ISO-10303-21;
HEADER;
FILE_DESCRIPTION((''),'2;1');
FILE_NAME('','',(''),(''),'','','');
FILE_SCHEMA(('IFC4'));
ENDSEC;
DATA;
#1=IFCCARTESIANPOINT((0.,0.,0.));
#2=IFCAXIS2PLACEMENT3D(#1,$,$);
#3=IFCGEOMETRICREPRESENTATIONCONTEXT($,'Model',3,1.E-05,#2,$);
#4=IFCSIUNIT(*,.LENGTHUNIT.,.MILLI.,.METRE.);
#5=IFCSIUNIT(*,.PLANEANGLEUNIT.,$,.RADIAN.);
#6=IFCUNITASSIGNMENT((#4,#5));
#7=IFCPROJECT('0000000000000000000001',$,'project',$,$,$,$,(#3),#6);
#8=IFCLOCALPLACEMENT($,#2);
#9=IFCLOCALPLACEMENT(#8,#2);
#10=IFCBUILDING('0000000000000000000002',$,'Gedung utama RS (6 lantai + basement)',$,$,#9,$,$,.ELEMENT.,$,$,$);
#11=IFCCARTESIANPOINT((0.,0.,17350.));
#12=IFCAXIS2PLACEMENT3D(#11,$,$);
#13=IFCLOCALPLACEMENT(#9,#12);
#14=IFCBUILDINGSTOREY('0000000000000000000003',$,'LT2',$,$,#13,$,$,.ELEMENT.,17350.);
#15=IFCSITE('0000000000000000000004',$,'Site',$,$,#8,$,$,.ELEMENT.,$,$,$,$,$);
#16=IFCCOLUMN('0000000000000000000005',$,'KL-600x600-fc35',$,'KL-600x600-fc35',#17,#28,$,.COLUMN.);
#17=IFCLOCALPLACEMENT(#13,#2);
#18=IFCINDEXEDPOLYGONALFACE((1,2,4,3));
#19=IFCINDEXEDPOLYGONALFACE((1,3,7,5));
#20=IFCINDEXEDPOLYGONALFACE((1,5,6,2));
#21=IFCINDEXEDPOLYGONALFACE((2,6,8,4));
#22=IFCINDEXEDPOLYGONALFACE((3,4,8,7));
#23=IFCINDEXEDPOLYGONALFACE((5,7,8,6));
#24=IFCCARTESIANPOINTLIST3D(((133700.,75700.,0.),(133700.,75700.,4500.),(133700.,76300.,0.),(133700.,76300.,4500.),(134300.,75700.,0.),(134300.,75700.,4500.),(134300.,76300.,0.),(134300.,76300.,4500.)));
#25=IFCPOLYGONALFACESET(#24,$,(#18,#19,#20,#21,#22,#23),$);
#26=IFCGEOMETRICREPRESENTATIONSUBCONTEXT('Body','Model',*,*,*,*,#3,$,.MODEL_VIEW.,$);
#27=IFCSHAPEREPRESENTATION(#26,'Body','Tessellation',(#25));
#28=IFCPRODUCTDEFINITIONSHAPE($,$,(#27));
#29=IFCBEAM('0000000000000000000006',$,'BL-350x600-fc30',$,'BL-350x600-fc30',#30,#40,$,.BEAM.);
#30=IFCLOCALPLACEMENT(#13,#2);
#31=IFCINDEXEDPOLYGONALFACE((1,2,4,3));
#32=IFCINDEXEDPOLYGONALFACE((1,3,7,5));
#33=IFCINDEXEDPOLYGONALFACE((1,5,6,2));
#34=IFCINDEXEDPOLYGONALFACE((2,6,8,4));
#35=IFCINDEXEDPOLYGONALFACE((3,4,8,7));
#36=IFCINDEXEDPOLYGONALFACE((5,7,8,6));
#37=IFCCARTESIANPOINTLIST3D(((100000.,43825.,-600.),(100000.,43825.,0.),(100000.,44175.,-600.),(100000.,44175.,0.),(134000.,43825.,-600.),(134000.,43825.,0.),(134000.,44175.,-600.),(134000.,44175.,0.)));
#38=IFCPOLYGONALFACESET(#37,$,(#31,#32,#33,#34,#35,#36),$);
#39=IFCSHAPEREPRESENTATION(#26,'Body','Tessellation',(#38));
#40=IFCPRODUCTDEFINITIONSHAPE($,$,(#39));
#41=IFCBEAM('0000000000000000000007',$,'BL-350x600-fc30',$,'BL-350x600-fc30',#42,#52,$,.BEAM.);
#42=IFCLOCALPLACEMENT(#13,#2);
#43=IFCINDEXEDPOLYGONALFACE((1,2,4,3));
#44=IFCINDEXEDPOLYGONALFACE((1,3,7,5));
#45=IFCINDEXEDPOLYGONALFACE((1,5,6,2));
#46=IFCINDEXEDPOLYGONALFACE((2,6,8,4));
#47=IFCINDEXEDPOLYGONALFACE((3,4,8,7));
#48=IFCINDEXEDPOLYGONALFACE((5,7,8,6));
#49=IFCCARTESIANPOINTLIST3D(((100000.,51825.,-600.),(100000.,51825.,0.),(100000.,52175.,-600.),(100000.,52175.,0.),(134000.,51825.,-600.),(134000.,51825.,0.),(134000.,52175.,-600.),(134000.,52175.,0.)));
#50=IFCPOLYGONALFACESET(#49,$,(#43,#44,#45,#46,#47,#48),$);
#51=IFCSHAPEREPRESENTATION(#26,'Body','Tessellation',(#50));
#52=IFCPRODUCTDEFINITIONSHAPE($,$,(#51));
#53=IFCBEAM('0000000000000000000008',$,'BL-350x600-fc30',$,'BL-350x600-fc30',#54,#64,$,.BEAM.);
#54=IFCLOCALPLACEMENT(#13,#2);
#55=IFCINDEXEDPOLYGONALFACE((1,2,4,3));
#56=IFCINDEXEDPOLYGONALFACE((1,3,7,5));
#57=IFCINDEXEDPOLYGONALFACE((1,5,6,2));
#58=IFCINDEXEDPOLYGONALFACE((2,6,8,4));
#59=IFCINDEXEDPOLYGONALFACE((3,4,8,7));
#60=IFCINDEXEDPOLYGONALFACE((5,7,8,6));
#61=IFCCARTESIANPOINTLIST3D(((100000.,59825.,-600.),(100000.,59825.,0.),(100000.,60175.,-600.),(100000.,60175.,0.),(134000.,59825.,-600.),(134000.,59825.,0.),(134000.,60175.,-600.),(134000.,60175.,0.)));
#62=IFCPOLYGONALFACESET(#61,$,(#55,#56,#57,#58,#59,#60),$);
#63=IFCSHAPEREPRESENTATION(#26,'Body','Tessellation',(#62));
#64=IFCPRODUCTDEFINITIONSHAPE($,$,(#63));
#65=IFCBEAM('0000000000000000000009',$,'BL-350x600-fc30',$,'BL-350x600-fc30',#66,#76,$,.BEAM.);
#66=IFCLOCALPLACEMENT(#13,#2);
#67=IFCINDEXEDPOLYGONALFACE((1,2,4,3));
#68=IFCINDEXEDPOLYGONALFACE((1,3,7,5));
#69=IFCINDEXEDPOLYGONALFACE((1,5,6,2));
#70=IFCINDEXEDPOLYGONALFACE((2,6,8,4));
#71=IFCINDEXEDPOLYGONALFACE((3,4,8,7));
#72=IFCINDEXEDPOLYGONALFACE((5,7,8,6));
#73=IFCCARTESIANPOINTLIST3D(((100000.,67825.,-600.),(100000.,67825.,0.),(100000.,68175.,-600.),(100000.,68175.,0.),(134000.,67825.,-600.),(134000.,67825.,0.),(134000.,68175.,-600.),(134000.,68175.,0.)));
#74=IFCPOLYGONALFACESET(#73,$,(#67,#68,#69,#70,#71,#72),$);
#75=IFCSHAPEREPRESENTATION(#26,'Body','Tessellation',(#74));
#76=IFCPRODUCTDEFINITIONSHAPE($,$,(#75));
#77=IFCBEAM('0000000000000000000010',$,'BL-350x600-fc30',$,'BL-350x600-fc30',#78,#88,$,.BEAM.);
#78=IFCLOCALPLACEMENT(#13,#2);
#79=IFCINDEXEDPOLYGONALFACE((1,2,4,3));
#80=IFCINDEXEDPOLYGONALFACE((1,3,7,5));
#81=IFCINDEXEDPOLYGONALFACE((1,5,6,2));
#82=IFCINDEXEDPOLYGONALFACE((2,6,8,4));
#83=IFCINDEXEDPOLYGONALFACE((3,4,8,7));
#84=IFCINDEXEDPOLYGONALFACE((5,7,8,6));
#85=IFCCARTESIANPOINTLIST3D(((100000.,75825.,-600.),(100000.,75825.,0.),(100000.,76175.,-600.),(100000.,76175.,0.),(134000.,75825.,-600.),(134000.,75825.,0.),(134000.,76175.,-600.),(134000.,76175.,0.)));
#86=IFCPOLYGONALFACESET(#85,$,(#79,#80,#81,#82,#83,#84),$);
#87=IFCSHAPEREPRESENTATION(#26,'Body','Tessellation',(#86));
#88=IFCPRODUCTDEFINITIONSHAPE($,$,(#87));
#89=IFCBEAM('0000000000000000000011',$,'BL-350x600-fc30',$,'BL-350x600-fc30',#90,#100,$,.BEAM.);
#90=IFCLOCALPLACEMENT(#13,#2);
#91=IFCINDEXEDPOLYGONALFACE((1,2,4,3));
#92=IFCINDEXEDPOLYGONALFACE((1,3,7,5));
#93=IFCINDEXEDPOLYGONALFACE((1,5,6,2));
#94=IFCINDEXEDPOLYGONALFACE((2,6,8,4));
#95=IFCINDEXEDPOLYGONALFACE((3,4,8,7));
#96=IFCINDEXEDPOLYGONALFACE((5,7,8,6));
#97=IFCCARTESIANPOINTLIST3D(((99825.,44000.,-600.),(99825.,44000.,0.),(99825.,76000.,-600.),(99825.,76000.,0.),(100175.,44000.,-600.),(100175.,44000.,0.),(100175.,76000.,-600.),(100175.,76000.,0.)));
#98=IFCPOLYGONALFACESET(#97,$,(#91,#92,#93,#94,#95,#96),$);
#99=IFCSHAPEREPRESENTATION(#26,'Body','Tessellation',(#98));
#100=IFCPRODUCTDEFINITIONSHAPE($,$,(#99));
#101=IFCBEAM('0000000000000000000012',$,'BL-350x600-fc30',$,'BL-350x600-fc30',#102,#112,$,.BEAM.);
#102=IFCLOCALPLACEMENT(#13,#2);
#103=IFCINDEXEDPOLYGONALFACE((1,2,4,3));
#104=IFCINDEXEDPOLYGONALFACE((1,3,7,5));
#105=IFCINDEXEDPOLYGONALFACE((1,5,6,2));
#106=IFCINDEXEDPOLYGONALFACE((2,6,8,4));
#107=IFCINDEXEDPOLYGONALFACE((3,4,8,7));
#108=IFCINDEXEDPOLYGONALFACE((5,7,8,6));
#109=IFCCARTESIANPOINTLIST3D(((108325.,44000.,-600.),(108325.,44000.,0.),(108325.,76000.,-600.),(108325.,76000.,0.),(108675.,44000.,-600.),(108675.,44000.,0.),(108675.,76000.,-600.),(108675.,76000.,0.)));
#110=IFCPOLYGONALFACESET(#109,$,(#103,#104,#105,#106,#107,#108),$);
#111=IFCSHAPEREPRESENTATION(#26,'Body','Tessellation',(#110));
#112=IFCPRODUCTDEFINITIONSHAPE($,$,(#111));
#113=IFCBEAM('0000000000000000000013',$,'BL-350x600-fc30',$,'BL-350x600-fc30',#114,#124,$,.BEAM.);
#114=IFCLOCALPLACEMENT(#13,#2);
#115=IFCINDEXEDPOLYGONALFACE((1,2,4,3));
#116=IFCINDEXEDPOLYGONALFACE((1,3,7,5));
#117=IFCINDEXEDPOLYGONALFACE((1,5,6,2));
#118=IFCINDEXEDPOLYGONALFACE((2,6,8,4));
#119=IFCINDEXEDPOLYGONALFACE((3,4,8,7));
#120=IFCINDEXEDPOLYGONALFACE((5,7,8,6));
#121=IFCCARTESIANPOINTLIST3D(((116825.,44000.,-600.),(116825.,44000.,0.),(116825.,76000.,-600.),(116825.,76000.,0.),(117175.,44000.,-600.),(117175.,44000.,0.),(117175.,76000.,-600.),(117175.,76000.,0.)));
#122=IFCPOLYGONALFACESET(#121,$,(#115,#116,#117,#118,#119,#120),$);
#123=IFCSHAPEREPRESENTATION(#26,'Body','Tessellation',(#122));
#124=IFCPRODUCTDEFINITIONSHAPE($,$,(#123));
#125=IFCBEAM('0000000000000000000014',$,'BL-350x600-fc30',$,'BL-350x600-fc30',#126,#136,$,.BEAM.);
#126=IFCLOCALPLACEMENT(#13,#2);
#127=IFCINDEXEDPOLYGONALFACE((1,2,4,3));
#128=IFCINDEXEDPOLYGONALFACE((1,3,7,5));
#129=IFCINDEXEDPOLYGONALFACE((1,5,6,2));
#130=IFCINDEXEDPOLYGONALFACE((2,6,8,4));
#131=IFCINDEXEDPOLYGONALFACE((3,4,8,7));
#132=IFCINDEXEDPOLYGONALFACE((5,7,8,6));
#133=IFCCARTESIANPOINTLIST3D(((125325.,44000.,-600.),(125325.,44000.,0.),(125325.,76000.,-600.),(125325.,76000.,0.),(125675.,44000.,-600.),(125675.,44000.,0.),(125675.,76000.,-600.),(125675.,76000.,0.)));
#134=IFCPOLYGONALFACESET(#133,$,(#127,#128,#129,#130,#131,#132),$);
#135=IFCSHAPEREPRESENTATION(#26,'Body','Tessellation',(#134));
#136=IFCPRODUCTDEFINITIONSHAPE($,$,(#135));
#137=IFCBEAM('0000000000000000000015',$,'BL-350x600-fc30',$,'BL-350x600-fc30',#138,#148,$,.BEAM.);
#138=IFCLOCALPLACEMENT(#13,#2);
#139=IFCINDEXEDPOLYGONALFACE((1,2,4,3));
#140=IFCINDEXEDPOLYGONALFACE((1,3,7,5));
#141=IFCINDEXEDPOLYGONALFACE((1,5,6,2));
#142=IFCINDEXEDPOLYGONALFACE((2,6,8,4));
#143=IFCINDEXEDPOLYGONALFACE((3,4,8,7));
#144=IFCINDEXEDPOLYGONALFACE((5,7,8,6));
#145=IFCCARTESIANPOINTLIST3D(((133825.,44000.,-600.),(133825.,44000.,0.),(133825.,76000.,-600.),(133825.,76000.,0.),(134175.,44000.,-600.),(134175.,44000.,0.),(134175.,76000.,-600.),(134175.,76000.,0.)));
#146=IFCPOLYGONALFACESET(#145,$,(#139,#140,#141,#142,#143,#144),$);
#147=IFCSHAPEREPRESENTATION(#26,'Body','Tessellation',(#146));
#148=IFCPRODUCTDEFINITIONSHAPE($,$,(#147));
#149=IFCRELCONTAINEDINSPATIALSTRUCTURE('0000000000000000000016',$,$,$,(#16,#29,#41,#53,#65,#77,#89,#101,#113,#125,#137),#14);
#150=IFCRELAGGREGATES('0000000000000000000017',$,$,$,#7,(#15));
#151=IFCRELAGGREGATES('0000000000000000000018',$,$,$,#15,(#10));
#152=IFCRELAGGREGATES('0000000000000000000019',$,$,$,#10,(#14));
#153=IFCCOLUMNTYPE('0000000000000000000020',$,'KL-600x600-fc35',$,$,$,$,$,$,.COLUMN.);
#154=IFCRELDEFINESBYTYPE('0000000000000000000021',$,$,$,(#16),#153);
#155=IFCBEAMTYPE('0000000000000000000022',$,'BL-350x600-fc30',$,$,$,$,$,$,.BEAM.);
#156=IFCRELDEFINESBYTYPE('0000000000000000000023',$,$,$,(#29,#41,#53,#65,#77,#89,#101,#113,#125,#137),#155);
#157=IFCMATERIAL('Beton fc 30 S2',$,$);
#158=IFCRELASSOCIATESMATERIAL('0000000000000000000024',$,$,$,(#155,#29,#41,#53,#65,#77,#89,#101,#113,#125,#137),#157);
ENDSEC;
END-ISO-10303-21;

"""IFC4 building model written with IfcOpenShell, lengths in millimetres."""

from ifc_helpers import new_model, si_unit, frame, origin, origin_2d, place, context, subcontext, project, spatial, rectangle, extrude, material, material_profile, profile_set, profile_usage, type_object, element, save


model = new_model("IFC4")

# Units and contexts
model_context = context("Model", 3, precision=1e-05, world=origin())
body_context = subcontext(model_context, "Body", "Model", "MODEL_VIEW")
ifc_project = project(units=[si_unit("LENGTHUNIT", "METRE", prefix="MILLI"), si_unit("PLANEANGLEUNIT", "RADIAN")], contexts=[model_context])

# Site, building, storey
site_placement = place(None, origin())
site = spatial("IfcSite", under=ifc_project, at=site_placement, Name="Site", CompositionType="ELEMENT")
building_placement = place(site_placement, origin())
building = spatial("IfcBuilding", under=site, at=building_placement, Name="Gedung utama RS (6 lantai + basement)", CompositionType="ELEMENT")
storey_placement = place(building_placement, frame((0.0, 0.0, 17350.0)))
storey = spatial("IfcBuildingStorey", under=building, at=storey_placement, Name="LT2", CompositionType="ELEMENT", Elevation=17350.0)

# Column
ifc_material_profile_1 = material_profile(None, rectangle(XDim=600.0, YDim=600.0, at=origin_2d()), Name="KL-600x600-fc35")
ifc_profile_set_1 = profile_set([ifc_material_profile_1], Name="KL-600x600-fc35")
ifc_profile_usage_1 = profile_usage(ifc_profile_set_1, cardinal=5)
column_type = type_object("IfcColumnType", Name="KL-600x600-fc35", PredefinedType="COLUMN", material=ifc_profile_set_1)
for number, where, z_axis, x_axis, name in (
    (1, (134000.0, 76000.0, 0.0), (0.0, 0.0, 1.0), (1.0, 0.0, 0.0), "KL-600x600-fc35"),
):
    element("IfcColumn", number, at=place(storey_placement, frame(where, z_axis=z_axis, x_axis=x_axis)), inside=storey, type_object=column_type, material=ifc_profile_usage_1, Name=name, ObjectType="KL-600x600-fc35", PredefinedType="COLUMN", context=body_context, shape_type="SweptSolid", body=[
        extrude(rectangle(XDim=600.0, YDim=600.0, at=origin_2d()), origin(), (0.0, 0.0, 1.0), 4500.0),
    ])

# Beams
ifc_material = material(Name="Beton fc 30 S2")
ifc_material_profile_2 = material_profile(ifc_material, rectangle(XDim=350.0, YDim=600.0, at=origin_2d()), Name="BL-350x600-fc30")
ifc_profile_set_2 = profile_set([ifc_material_profile_2], Name="BL-350x600-fc30")
ifc_profile_usage_2 = profile_usage(ifc_profile_set_2, cardinal=8)
beam_type = type_object("IfcBeamType", Name="BL-350x600-fc30", PredefinedType="BEAM", material=ifc_profile_set_2)
for number, where, name in (
    (2, (100000.0, 44000.0, -300.0), "BL-350x600-fc30"),
    (3, (100000.0, 52000.0, -300.0), "BL-350x600-fc30"),
    (4, (100000.0, 60000.0, -300.0), "BL-350x600-fc30"),
    (5, (100000.0, 68000.0, -300.0), "BL-350x600-fc30"),
    (6, (100000.0, 76000.0, -300.0), "BL-350x600-fc30"),
):
    element("IfcBeam", number, at=place(storey_placement, frame(where)), inside=storey, type_object=beam_type, material=ifc_profile_usage_2, Name=name, ObjectType="BL-350x600-fc30", PredefinedType="BEAM", context=body_context, shape_type="SweptSolid", body=[
        extrude(rectangle(XDim=350.0, YDim=600.0, at=origin_2d()), frame((0.0, 0.0, 0.0), z_axis=(1.0, 0.0, 0.0), x_axis=(0.0, 1.0, 0.0)), (0.0, 0.0, 1.0), 34000.0),
    ])
for number, where, name in (
    (7, (100000.0, 44000.0, -300.0), "BL-350x600-fc30"),
    (8, (108500.0, 44000.0, -300.0), "BL-350x600-fc30"),
    (9, (117000.0, 44000.0, -300.0), "BL-350x600-fc30"),
    (10, (125500.0, 44000.0, -300.0), "BL-350x600-fc30"),
    (11, (134000.0, 44000.0, -300.0), "BL-350x600-fc30"),
):
    element("IfcBeam", number, at=place(storey_placement, frame(where)), inside=storey, type_object=beam_type, material=ifc_profile_usage_2, Name=name, ObjectType="BL-350x600-fc30", PredefinedType="BEAM", context=body_context, shape_type="SweptSolid", body=[
        extrude(rectangle(XDim=350.0, YDim=600.0, at=origin_2d()), frame((0.0, 0.0, 0.0), z_axis=(0.0, 1.0, 0.0), x_axis=(-1.0, 0.0, 0.0)), (0.0, 0.0, 1.0), 32000.0),
    ])

save(model, "model.ifc")
